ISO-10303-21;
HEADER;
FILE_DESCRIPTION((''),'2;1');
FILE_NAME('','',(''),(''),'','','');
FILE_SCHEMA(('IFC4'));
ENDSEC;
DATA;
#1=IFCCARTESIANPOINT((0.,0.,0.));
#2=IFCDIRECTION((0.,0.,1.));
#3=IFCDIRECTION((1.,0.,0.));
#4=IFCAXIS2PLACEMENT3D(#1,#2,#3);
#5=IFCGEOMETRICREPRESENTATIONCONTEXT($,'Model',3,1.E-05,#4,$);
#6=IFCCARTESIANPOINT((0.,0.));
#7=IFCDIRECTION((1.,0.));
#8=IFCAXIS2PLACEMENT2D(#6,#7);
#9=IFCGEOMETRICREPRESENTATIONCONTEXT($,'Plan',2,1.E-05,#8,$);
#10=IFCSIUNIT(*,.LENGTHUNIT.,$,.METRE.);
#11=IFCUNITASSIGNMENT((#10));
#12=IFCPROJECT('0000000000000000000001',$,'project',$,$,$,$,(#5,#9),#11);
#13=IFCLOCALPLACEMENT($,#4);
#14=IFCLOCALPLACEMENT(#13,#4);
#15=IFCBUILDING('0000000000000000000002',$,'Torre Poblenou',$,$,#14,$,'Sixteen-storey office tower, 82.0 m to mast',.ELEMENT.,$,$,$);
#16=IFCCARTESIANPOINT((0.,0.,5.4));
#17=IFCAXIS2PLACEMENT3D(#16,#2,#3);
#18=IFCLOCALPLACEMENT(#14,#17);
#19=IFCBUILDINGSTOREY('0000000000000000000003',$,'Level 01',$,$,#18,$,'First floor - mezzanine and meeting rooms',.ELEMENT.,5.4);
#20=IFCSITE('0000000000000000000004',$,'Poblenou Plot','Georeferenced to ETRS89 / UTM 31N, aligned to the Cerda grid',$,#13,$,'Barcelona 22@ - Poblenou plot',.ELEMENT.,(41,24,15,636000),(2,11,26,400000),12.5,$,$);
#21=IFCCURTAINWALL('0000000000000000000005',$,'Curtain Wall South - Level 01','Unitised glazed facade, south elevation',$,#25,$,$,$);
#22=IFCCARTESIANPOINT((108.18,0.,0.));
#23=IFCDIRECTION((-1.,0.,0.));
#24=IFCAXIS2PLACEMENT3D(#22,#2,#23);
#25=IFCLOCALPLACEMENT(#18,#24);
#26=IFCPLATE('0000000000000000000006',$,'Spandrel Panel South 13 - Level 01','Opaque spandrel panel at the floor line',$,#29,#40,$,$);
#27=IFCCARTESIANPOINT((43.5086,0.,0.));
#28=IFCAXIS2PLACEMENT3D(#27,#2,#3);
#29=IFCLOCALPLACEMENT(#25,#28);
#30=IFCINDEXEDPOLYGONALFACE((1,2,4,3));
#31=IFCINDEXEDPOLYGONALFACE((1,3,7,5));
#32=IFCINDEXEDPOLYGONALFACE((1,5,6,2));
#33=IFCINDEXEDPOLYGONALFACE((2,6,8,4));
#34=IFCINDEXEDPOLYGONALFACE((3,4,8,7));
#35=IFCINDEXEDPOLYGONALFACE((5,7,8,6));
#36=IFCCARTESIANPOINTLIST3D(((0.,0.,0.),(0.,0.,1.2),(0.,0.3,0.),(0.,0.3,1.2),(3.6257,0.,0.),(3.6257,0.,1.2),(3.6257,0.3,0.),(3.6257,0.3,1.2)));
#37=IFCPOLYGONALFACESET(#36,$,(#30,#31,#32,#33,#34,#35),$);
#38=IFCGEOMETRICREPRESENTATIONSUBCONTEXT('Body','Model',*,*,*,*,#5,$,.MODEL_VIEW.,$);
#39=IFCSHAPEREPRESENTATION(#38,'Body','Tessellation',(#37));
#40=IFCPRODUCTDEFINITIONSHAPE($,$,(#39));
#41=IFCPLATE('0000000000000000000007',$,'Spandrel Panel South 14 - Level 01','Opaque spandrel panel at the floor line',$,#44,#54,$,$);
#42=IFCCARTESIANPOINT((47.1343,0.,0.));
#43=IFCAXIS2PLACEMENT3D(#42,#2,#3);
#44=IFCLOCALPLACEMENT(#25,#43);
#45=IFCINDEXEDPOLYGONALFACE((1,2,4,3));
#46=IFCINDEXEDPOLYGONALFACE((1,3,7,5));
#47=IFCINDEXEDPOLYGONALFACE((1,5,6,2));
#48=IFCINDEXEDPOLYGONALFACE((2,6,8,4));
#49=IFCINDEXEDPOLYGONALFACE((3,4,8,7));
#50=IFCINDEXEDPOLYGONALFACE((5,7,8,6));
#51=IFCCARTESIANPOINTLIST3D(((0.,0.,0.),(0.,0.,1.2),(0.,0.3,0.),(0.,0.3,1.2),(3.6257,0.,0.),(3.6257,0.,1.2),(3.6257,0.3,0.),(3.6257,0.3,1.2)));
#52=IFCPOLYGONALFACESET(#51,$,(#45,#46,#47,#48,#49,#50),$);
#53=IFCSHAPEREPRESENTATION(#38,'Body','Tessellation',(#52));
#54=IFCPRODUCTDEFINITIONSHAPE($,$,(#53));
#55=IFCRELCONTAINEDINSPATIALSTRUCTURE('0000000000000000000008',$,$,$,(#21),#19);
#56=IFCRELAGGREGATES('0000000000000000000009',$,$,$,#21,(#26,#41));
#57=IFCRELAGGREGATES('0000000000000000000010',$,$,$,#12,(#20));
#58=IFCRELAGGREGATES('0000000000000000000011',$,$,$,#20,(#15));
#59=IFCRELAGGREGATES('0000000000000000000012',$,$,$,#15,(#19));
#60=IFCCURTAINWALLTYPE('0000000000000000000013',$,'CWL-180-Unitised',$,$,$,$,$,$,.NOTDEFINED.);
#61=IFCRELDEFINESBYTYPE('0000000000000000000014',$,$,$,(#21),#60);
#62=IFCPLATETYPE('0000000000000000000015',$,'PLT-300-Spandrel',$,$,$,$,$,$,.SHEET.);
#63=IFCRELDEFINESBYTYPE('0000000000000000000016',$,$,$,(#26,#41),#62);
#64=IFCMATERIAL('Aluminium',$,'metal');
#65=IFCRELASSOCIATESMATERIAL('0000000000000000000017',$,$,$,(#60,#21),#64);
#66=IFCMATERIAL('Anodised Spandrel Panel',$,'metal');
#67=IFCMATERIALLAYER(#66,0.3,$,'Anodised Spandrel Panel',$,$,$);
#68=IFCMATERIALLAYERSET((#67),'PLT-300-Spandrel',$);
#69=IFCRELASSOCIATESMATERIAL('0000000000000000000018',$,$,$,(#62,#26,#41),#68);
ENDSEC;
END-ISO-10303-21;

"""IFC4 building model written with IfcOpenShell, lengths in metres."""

from ifc_helpers import new_model, si_unit, frame, origin_with_axes, origin_2d_with_axis, place, context, subcontext, project, spatial, line, indexed_curve, outline, extrude, material, layer, layer_set, layer_usage, type_object, element, aggregate, save


model = new_model("IFC4")

# Units and contexts
model_context = context("Model", 3, precision=1e-05, world=origin_with_axes())
plan_context = context("Plan", 2, precision=1e-05, world=origin_2d_with_axis())
body_context = subcontext(model_context, "Body", "Model", "MODEL_VIEW")
ifc_project = project(units=[si_unit("LENGTHUNIT", "METRE")], contexts=[model_context, plan_context])

# Site, building, storey
site_placement = place(None, origin_with_axes())
site = spatial("IfcSite", under=ifc_project, at=site_placement, Name="Poblenou Plot", Description="Georeferenced to ETRS89 / UTM 31N, aligned to the Cerda grid", LongName="Barcelona 22@ - Poblenou plot", CompositionType="ELEMENT", RefLatitude=(41, 24, 15, 636000), RefLongitude=(2, 11, 26, 400000), RefElevation=12.5)
building_placement = place(site_placement, origin_with_axes())
building = spatial("IfcBuilding", under=site, at=building_placement, Name="Torre Poblenou", LongName="Sixteen-storey office tower, 82.0 m to mast", CompositionType="ELEMENT")
storey_placement = place(building_placement, frame((0.0, 0.0, 5.4), z_axis=(0.0, 0.0, 1.0), x_axis=(1.0, 0.0, 0.0)))
storey = spatial("IfcBuildingStorey", under=building, at=storey_placement, Name="Level 01", LongName="First floor - mezzanine and meeting rooms", CompositionType="ELEMENT", Elevation=5.4)

# Curtain wall
ifc_material_1 = material(Name="Aluminium", Category="metal")
curtain_wall_type = type_object("IfcCurtainWallType", Name="CWL-180-Unitised", PredefinedType="NOTDEFINED", material=ifc_material_1)
curtain_wall_1_placement = place(storey_placement, frame((108.18, 0.0, 0.0), z_axis=(0.0, 0.0, 1.0), x_axis=(-1.0, 0.0, 0.0)))
curtain_wall_1 = element("IfcCurtainWall", 1, at=curtain_wall_1_placement, inside=storey, type_object=curtain_wall_type, material=ifc_material_1, Name="Curtain Wall South - Level 01", Description="Unitised glazed facade, south elevation")

# Plates
ifc_material_2 = material(Name="Anodised Spandrel Panel", Category="metal")
ifc_layer_1 = layer(ifc_material_2, 0.3, Name="Anodised Spandrel Panel")
ifc_layer_set_1 = layer_set([ifc_layer_1], Name="PLT-300-Spandrel")
ifc_layer_usage_1 = layer_usage(ifc_layer_set_1, "AXIS2", "POSITIVE", 0.0)
plate_type_1 = type_object("IfcPlateType", Name="PLT-300-Spandrel", PredefinedType="SHEET", material=ifc_layer_set_1)
plate_1_placement = place(curtain_wall_1_placement, frame((43.5086, 0.0, 0.0), z_axis=(0.0, 0.0, 1.0), x_axis=(1.0, 0.0, 0.0)))
plate_1 = element("IfcPlate", 2, at=plate_1_placement, type_object=plate_type_1, material=ifc_layer_usage_1, Name="Spandrel Panel South 13 - Level 01", Description="Opaque spandrel panel at the floor line", context=body_context, shape_type="SweptSolid", body=[
    extrude(outline(indexed_curve([(0.0, 0.0), (3.6257, 0.0), (3.6257, 0.3), (0.0, 0.3)], segments=[line(1, 2, 3, 4, 1)])), origin_with_axes(), (0.0, 0.0, 1.0), 1.2),
])
ifc_layer_usage_2 = layer_usage(ifc_layer_set_1, "AXIS2", "POSITIVE", 0.0)
plate_2_placement = place(curtain_wall_1_placement, frame((47.1343, 0.0, 0.0), z_axis=(0.0, 0.0, 1.0), x_axis=(1.0, 0.0, 0.0)))
plate_2 = element("IfcPlate", 3, at=plate_2_placement, type_object=plate_type_1, material=ifc_layer_usage_2, Name="Spandrel Panel South 14 - Level 01", Description="Opaque spandrel panel at the floor line", context=body_context, shape_type="SweptSolid", body=[
    extrude(outline(indexed_curve([(0.0, 0.0), (3.6257, 0.0), (3.6257, 0.3), (0.0, 0.3)], segments=[line(1, 2, 3, 4, 1)])), origin_with_axes(), (0.0, 0.0, 1.0), 1.2),
])
aggregate(curtain_wall_1, [plate_1, plate_2])

save(model, "model.ifc")
